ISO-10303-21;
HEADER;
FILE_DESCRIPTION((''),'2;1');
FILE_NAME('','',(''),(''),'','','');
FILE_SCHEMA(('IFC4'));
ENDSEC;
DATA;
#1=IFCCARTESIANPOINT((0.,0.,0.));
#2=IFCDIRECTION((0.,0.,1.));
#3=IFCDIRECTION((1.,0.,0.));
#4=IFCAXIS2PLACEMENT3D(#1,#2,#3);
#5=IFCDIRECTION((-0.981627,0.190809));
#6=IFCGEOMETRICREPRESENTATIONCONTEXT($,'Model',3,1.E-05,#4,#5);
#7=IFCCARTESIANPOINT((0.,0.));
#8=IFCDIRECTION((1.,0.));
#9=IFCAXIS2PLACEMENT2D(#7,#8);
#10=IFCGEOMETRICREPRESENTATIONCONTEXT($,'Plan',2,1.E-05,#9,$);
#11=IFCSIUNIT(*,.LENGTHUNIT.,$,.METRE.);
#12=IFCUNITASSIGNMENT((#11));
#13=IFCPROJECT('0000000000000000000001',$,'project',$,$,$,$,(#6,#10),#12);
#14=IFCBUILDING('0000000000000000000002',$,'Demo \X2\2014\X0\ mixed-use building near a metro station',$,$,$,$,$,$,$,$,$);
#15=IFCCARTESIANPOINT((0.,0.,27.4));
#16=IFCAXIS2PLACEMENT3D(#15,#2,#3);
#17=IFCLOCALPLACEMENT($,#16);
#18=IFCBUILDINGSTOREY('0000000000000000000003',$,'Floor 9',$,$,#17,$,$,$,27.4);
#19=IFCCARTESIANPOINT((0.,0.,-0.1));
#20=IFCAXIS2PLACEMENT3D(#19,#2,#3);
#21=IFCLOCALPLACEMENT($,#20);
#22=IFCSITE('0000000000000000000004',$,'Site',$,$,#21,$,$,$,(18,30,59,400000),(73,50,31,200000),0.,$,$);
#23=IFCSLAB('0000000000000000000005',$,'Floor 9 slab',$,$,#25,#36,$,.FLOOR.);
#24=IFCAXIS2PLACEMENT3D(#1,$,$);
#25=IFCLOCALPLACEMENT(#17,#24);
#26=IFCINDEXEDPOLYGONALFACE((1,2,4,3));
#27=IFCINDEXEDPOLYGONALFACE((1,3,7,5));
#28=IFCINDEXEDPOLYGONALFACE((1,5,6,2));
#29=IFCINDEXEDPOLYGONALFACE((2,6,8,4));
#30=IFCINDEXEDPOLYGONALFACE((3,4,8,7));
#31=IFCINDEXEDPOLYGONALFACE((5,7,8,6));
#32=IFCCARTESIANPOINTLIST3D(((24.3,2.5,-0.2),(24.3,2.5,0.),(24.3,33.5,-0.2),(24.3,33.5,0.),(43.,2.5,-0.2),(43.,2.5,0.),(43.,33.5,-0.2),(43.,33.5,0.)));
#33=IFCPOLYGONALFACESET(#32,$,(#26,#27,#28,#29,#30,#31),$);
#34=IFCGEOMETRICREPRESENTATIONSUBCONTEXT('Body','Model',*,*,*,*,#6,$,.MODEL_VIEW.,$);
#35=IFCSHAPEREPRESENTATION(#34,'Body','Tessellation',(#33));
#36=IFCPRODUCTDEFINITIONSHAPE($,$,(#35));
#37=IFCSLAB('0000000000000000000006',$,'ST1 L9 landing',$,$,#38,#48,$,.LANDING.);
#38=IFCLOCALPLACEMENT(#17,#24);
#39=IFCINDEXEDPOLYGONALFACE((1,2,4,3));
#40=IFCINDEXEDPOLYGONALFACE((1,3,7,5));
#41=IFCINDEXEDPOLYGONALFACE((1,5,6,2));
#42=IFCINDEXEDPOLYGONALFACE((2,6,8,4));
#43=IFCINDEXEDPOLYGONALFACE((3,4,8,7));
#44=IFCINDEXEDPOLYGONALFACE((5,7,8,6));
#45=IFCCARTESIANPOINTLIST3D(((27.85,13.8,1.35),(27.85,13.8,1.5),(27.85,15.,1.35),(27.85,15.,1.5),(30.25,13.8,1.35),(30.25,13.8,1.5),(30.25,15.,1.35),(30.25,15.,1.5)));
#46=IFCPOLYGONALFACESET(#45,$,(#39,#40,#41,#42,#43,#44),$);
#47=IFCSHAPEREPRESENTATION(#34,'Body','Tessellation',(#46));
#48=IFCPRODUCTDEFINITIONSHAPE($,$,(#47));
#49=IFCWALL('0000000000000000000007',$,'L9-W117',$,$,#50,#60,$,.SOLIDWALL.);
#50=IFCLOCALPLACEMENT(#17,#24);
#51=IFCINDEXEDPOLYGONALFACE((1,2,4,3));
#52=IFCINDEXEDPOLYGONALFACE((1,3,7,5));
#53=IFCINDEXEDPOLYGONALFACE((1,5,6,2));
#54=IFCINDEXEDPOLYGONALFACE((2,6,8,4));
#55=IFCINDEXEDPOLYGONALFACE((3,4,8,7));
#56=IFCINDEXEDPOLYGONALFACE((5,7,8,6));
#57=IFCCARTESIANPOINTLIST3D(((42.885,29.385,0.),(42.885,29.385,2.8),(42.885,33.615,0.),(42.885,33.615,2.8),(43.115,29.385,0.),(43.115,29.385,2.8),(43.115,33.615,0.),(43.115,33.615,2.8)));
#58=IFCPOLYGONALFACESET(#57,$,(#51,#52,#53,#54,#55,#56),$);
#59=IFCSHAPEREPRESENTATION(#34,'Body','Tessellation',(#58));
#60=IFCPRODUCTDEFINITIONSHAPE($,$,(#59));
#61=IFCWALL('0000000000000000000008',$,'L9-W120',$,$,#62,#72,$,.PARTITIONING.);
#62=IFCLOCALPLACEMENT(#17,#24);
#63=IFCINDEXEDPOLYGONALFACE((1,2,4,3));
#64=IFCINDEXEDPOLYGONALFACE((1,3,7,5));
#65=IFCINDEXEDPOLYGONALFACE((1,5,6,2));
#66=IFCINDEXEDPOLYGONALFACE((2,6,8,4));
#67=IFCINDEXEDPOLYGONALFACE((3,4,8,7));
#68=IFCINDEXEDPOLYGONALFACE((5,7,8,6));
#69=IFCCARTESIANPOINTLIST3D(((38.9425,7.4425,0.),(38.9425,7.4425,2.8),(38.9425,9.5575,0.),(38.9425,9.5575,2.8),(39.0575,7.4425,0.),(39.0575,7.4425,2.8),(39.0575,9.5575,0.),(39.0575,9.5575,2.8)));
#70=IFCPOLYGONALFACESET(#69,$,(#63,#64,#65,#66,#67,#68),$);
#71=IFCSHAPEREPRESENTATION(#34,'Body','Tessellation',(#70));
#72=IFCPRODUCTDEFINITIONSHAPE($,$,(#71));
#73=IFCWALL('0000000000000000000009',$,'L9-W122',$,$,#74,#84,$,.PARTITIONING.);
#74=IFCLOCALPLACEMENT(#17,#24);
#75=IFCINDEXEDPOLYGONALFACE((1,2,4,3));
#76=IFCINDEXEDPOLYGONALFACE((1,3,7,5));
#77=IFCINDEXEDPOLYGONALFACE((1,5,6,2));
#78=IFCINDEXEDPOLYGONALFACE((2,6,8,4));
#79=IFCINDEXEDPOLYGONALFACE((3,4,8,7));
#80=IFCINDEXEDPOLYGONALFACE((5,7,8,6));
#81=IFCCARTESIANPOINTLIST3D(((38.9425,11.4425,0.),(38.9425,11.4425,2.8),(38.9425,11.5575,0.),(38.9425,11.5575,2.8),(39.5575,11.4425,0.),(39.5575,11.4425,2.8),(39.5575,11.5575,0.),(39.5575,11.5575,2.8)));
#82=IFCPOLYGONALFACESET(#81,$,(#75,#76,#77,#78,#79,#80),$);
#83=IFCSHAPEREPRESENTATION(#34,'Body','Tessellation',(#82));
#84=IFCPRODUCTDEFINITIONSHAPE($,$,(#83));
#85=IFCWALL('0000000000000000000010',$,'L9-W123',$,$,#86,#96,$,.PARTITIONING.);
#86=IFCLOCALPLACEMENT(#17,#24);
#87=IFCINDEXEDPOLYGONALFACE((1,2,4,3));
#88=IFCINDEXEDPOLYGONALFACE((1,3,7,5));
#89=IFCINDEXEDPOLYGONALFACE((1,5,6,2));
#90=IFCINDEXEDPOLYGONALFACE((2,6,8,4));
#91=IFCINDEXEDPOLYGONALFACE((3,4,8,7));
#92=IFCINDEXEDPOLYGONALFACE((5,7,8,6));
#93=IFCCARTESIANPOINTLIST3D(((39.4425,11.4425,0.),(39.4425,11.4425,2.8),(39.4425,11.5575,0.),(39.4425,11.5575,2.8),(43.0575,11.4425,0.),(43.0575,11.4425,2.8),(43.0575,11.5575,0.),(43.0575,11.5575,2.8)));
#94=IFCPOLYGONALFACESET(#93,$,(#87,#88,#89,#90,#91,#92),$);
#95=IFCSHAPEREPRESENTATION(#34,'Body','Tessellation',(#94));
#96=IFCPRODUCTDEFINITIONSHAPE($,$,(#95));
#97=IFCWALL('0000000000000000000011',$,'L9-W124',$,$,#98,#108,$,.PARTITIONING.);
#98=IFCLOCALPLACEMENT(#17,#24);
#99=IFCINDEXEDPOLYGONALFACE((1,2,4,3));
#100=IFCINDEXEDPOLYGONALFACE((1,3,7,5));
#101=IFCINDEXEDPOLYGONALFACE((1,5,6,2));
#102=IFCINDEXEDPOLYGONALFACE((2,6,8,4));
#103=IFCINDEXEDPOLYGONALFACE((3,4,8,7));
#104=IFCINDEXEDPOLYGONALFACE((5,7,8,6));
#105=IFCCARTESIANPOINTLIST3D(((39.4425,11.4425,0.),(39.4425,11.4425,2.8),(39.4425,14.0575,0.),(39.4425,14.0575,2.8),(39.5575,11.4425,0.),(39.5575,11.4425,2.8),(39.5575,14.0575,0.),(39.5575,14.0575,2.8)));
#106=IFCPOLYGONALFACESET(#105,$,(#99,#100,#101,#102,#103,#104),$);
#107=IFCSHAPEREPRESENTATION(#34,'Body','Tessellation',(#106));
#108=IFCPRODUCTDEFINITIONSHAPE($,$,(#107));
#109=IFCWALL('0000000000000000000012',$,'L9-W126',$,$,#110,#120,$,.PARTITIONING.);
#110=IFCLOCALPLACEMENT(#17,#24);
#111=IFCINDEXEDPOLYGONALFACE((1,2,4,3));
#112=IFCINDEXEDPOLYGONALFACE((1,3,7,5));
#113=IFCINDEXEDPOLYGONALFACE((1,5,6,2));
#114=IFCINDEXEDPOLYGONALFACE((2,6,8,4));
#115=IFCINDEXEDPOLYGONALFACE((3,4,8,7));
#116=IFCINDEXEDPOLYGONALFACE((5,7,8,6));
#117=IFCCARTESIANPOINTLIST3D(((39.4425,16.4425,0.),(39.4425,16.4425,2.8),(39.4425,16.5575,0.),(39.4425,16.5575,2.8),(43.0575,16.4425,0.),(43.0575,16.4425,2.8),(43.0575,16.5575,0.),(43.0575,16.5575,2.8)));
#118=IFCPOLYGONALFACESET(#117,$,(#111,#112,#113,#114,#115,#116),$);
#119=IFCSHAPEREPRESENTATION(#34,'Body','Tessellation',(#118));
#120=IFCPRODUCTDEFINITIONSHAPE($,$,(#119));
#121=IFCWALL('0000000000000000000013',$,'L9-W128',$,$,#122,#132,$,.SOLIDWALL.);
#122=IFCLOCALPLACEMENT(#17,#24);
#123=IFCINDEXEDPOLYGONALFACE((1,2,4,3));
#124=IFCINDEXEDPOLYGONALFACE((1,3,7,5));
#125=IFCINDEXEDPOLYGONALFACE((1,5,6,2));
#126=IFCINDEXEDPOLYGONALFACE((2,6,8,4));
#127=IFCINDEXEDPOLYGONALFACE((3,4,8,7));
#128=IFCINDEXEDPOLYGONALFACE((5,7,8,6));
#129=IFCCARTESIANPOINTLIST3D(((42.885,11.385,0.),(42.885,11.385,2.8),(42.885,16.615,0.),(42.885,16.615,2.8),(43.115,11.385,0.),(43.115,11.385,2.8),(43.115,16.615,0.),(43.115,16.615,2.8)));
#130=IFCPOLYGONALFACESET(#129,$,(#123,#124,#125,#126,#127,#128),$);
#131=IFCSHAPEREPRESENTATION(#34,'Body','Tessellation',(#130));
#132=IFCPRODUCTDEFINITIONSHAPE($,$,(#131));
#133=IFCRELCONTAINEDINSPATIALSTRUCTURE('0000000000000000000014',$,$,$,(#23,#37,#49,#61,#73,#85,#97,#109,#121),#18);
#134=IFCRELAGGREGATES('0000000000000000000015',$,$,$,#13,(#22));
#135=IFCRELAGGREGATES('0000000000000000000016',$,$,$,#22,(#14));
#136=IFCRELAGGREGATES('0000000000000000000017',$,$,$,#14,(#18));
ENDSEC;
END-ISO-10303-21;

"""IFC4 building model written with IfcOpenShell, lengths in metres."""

from ifc_helpers import new_model, si_unit, direction, frame, origin_with_axes, origin_2d_with_axis, place, context, subcontext, project, spatial, line, indexed_curve, outline, extrude, element, save


model = new_model("IFC4")

# Units and contexts
model_context = context("Model", 3, precision=1e-05, world=origin_with_axes(), true_north=direction((-0.981627, 0.190809)))
plan_context = context("Plan", 2, precision=1e-05, world=origin_2d_with_axis())
body_context = subcontext(model_context, "Body", "Model", "MODEL_VIEW")
ifc_project = project(units=[si_unit("LENGTHUNIT", "METRE")], contexts=[model_context, plan_context])

# Site, building, storey
site_placement = place(None, frame((0.0, 0.0, -0.1), z_axis=(0.0, 0.0, 1.0), x_axis=(1.0, 0.0, 0.0)))
site = spatial("IfcSite", under=ifc_project, at=site_placement, Name="Site", RefLatitude=(18, 30, 59, 400000), RefLongitude=(73, 50, 31, 200000), RefElevation=0.0)
building = spatial("IfcBuilding", under=site, Name="Demo — mixed-use building near a metro station")
storey_placement = place(None, frame((0.0, 0.0, 27.4), z_axis=(0.0, 0.0, 1.0), x_axis=(1.0, 0.0, 0.0)))
storey = spatial("IfcBuildingStorey", under=building, at=storey_placement, Name="Floor 9", Elevation=27.4)

# Slabs
slab_1_placement = place(storey_placement, frame((0.0, 0.0, -0.2), z_axis=(0.0, 0.0, 1.0), x_axis=(1.0, 0.0, 0.0)))
element("IfcSlab", 1, at=slab_1_placement, inside=storey, Name="Floor 9 slab", PredefinedType="FLOOR", context=body_context, shape_type="SweptSolid", body=[
    extrude(outline(indexed_curve([(24.3, 2.5), (43.0, 2.5), (43.0, 33.5), (24.3, 33.5)], segments=[line(1, 2, 3, 4, 1)])), origin_with_axes(), (0.0, 0.0, 1.0), 0.2),
])
slab_2_placement = place(storey_placement, frame((0.0, 0.0, -27.4), z_axis=(0.0, 0.0, 1.0), x_axis=(1.0, 0.0, 0.0)))
element("IfcSlab", 2, at=slab_2_placement, inside=storey, Name="ST1 L9 landing", PredefinedType="LANDING", context=body_context, shape_type="SweptSolid", body=[
    extrude(outline(indexed_curve([(27.85, 13.8), (30.25, 13.8), (30.25, 15.0), (27.85, 15.0)], segments=[line(1, 2, 3, 4, 1)])), frame((0.0, 0.0, 28.75), z_axis=(0.0, 0.0, 1.0), x_axis=(1.0, 0.0, 0.0)), (0.0, 0.0, 1.0), 0.15),
])

# Wall
wall_1_placement = place(storey_placement, frame((0.0, 0.0, -27.4), z_axis=(0.0, 0.0, 1.0), x_axis=(1.0, 0.0, 0.0)))
element("IfcWall", 3, at=wall_1_placement, inside=storey, Name="L9-W117", PredefinedType="SOLIDWALL", context=body_context, shape_type="SweptSolid", body=[
    extrude(outline(indexed_curve([(42.885, 29.385), (42.885, 33.615), (43.115, 33.615), (43.115, 29.385)], segments=[line(1, 2, 3, 4, 1)])), frame((0.0, 0.0, 27.4), z_axis=(0.0, 0.0, 1.0), x_axis=(1.0, 0.0, 0.0)), (0.0, 0.0, 1.0), 2.8),
])

# Wall
wall_2_placement = place(storey_placement, frame((0.0, 0.0, -27.4), z_axis=(0.0, 0.0, 1.0), x_axis=(1.0, 0.0, 0.0)))
element("IfcWall", 4, at=wall_2_placement, inside=storey, Name="L9-W120", PredefinedType="PARTITIONING", context=body_context, shape_type="SweptSolid", body=[
    extrude(outline(indexed_curve([(39.0575, 9.5575), (39.0575, 7.4425), (38.9425, 7.4425), (38.9425, 9.5575)], segments=[line(1, 2, 3, 4, 1)])), frame((0.0, 0.0, 27.4), z_axis=(0.0, 0.0, 1.0), x_axis=(1.0, 0.0, 0.0)), (0.0, 0.0, 1.0), 2.8),
])

# Walls
wall_3_placement = place(storey_placement, frame((0.0, 0.0, -27.4), z_axis=(0.0, 0.0, 1.0), x_axis=(1.0, 0.0, 0.0)))
element("IfcWall", 5, at=wall_3_placement, inside=storey, Name="L9-W122", PredefinedType="PARTITIONING", context=body_context, shape_type="SweptSolid", body=[
    extrude(outline(indexed_curve([(38.9425, 11.5575), (39.5575, 11.5575), (39.5575, 11.4425), (38.9425, 11.4425)], segments=[line(1, 2, 3, 4, 1)])), frame((0.0, 0.0, 27.4), z_axis=(0.0, 0.0, 1.0), x_axis=(1.0, 0.0, 0.0)), (0.0, 0.0, 1.0), 2.8),
])
wall_4_placement = place(storey_placement, frame((0.0, 0.0, -27.4), z_axis=(0.0, 0.0, 1.0), x_axis=(1.0, 0.0, 0.0)))
element("IfcWall", 6, at=wall_4_placement, inside=storey, Name="L9-W123", PredefinedType="PARTITIONING", context=body_context, shape_type="SweptSolid", body=[
    extrude(outline(indexed_curve([(39.4425, 11.5575), (43.0575, 11.5575), (43.0575, 11.4425), (39.4425, 11.4425)], segments=[line(1, 2, 3, 4, 1)])), frame((0.0, 0.0, 27.4), z_axis=(0.0, 0.0, 1.0), x_axis=(1.0, 0.0, 0.0)), (0.0, 0.0, 1.0), 2.8),
])
wall_5_placement = place(storey_placement, frame((0.0, 0.0, -27.4), z_axis=(0.0, 0.0, 1.0), x_axis=(1.0, 0.0, 0.0)))
element("IfcWall", 7, at=wall_5_placement, inside=storey, Name="L9-W124", PredefinedType="PARTITIONING", context=body_context, shape_type="SweptSolid", body=[
    extrude(outline(indexed_curve([(39.4425, 11.4425), (39.4425, 14.0575), (39.5575, 14.0575), (39.5575, 11.4425)], segments=[line(1, 2, 3, 4, 1)])), frame((0.0, 0.0, 27.4), z_axis=(0.0, 0.0, 1.0), x_axis=(1.0, 0.0, 0.0)), (0.0, 0.0, 1.0), 2.8),
])

# Wall
wall_6_placement = place(storey_placement, frame((0.0, 0.0, -27.4), z_axis=(0.0, 0.0, 1.0), x_axis=(1.0, 0.0, 0.0)))
element("IfcWall", 8, at=wall_6_placement, inside=storey, Name="L9-W126", PredefinedType="PARTITIONING", context=body_context, shape_type="SweptSolid", body=[
    extrude(outline(indexed_curve([(43.0575, 16.4425), (39.4425, 16.4425), (39.4425, 16.5575), (43.0575, 16.5575)], segments=[line(1, 2, 3, 4, 1)])), frame((0.0, 0.0, 27.4), z_axis=(0.0, 0.0, 1.0), x_axis=(1.0, 0.0, 0.0)), (0.0, 0.0, 1.0), 2.8),
])

# Wall
wall_7_placement = place(storey_placement, frame((0.0, 0.0, -27.4), z_axis=(0.0, 0.0, 1.0), x_axis=(1.0, 0.0, 0.0)))
element("IfcWall", 9, at=wall_7_placement, inside=storey, Name="L9-W128", PredefinedType="SOLIDWALL", context=body_context, shape_type="SweptSolid", body=[
    extrude(outline(indexed_curve([(42.885, 11.385), (42.885, 16.615), (43.115, 16.615), (43.115, 11.385)], segments=[line(1, 2, 3, 4, 1)])), frame((0.0, 0.0, 27.4), z_axis=(0.0, 0.0, 1.0), x_axis=(1.0, 0.0, 0.0)), (0.0, 0.0, 1.0), 2.8),
])

save(model, "model.ifc")
